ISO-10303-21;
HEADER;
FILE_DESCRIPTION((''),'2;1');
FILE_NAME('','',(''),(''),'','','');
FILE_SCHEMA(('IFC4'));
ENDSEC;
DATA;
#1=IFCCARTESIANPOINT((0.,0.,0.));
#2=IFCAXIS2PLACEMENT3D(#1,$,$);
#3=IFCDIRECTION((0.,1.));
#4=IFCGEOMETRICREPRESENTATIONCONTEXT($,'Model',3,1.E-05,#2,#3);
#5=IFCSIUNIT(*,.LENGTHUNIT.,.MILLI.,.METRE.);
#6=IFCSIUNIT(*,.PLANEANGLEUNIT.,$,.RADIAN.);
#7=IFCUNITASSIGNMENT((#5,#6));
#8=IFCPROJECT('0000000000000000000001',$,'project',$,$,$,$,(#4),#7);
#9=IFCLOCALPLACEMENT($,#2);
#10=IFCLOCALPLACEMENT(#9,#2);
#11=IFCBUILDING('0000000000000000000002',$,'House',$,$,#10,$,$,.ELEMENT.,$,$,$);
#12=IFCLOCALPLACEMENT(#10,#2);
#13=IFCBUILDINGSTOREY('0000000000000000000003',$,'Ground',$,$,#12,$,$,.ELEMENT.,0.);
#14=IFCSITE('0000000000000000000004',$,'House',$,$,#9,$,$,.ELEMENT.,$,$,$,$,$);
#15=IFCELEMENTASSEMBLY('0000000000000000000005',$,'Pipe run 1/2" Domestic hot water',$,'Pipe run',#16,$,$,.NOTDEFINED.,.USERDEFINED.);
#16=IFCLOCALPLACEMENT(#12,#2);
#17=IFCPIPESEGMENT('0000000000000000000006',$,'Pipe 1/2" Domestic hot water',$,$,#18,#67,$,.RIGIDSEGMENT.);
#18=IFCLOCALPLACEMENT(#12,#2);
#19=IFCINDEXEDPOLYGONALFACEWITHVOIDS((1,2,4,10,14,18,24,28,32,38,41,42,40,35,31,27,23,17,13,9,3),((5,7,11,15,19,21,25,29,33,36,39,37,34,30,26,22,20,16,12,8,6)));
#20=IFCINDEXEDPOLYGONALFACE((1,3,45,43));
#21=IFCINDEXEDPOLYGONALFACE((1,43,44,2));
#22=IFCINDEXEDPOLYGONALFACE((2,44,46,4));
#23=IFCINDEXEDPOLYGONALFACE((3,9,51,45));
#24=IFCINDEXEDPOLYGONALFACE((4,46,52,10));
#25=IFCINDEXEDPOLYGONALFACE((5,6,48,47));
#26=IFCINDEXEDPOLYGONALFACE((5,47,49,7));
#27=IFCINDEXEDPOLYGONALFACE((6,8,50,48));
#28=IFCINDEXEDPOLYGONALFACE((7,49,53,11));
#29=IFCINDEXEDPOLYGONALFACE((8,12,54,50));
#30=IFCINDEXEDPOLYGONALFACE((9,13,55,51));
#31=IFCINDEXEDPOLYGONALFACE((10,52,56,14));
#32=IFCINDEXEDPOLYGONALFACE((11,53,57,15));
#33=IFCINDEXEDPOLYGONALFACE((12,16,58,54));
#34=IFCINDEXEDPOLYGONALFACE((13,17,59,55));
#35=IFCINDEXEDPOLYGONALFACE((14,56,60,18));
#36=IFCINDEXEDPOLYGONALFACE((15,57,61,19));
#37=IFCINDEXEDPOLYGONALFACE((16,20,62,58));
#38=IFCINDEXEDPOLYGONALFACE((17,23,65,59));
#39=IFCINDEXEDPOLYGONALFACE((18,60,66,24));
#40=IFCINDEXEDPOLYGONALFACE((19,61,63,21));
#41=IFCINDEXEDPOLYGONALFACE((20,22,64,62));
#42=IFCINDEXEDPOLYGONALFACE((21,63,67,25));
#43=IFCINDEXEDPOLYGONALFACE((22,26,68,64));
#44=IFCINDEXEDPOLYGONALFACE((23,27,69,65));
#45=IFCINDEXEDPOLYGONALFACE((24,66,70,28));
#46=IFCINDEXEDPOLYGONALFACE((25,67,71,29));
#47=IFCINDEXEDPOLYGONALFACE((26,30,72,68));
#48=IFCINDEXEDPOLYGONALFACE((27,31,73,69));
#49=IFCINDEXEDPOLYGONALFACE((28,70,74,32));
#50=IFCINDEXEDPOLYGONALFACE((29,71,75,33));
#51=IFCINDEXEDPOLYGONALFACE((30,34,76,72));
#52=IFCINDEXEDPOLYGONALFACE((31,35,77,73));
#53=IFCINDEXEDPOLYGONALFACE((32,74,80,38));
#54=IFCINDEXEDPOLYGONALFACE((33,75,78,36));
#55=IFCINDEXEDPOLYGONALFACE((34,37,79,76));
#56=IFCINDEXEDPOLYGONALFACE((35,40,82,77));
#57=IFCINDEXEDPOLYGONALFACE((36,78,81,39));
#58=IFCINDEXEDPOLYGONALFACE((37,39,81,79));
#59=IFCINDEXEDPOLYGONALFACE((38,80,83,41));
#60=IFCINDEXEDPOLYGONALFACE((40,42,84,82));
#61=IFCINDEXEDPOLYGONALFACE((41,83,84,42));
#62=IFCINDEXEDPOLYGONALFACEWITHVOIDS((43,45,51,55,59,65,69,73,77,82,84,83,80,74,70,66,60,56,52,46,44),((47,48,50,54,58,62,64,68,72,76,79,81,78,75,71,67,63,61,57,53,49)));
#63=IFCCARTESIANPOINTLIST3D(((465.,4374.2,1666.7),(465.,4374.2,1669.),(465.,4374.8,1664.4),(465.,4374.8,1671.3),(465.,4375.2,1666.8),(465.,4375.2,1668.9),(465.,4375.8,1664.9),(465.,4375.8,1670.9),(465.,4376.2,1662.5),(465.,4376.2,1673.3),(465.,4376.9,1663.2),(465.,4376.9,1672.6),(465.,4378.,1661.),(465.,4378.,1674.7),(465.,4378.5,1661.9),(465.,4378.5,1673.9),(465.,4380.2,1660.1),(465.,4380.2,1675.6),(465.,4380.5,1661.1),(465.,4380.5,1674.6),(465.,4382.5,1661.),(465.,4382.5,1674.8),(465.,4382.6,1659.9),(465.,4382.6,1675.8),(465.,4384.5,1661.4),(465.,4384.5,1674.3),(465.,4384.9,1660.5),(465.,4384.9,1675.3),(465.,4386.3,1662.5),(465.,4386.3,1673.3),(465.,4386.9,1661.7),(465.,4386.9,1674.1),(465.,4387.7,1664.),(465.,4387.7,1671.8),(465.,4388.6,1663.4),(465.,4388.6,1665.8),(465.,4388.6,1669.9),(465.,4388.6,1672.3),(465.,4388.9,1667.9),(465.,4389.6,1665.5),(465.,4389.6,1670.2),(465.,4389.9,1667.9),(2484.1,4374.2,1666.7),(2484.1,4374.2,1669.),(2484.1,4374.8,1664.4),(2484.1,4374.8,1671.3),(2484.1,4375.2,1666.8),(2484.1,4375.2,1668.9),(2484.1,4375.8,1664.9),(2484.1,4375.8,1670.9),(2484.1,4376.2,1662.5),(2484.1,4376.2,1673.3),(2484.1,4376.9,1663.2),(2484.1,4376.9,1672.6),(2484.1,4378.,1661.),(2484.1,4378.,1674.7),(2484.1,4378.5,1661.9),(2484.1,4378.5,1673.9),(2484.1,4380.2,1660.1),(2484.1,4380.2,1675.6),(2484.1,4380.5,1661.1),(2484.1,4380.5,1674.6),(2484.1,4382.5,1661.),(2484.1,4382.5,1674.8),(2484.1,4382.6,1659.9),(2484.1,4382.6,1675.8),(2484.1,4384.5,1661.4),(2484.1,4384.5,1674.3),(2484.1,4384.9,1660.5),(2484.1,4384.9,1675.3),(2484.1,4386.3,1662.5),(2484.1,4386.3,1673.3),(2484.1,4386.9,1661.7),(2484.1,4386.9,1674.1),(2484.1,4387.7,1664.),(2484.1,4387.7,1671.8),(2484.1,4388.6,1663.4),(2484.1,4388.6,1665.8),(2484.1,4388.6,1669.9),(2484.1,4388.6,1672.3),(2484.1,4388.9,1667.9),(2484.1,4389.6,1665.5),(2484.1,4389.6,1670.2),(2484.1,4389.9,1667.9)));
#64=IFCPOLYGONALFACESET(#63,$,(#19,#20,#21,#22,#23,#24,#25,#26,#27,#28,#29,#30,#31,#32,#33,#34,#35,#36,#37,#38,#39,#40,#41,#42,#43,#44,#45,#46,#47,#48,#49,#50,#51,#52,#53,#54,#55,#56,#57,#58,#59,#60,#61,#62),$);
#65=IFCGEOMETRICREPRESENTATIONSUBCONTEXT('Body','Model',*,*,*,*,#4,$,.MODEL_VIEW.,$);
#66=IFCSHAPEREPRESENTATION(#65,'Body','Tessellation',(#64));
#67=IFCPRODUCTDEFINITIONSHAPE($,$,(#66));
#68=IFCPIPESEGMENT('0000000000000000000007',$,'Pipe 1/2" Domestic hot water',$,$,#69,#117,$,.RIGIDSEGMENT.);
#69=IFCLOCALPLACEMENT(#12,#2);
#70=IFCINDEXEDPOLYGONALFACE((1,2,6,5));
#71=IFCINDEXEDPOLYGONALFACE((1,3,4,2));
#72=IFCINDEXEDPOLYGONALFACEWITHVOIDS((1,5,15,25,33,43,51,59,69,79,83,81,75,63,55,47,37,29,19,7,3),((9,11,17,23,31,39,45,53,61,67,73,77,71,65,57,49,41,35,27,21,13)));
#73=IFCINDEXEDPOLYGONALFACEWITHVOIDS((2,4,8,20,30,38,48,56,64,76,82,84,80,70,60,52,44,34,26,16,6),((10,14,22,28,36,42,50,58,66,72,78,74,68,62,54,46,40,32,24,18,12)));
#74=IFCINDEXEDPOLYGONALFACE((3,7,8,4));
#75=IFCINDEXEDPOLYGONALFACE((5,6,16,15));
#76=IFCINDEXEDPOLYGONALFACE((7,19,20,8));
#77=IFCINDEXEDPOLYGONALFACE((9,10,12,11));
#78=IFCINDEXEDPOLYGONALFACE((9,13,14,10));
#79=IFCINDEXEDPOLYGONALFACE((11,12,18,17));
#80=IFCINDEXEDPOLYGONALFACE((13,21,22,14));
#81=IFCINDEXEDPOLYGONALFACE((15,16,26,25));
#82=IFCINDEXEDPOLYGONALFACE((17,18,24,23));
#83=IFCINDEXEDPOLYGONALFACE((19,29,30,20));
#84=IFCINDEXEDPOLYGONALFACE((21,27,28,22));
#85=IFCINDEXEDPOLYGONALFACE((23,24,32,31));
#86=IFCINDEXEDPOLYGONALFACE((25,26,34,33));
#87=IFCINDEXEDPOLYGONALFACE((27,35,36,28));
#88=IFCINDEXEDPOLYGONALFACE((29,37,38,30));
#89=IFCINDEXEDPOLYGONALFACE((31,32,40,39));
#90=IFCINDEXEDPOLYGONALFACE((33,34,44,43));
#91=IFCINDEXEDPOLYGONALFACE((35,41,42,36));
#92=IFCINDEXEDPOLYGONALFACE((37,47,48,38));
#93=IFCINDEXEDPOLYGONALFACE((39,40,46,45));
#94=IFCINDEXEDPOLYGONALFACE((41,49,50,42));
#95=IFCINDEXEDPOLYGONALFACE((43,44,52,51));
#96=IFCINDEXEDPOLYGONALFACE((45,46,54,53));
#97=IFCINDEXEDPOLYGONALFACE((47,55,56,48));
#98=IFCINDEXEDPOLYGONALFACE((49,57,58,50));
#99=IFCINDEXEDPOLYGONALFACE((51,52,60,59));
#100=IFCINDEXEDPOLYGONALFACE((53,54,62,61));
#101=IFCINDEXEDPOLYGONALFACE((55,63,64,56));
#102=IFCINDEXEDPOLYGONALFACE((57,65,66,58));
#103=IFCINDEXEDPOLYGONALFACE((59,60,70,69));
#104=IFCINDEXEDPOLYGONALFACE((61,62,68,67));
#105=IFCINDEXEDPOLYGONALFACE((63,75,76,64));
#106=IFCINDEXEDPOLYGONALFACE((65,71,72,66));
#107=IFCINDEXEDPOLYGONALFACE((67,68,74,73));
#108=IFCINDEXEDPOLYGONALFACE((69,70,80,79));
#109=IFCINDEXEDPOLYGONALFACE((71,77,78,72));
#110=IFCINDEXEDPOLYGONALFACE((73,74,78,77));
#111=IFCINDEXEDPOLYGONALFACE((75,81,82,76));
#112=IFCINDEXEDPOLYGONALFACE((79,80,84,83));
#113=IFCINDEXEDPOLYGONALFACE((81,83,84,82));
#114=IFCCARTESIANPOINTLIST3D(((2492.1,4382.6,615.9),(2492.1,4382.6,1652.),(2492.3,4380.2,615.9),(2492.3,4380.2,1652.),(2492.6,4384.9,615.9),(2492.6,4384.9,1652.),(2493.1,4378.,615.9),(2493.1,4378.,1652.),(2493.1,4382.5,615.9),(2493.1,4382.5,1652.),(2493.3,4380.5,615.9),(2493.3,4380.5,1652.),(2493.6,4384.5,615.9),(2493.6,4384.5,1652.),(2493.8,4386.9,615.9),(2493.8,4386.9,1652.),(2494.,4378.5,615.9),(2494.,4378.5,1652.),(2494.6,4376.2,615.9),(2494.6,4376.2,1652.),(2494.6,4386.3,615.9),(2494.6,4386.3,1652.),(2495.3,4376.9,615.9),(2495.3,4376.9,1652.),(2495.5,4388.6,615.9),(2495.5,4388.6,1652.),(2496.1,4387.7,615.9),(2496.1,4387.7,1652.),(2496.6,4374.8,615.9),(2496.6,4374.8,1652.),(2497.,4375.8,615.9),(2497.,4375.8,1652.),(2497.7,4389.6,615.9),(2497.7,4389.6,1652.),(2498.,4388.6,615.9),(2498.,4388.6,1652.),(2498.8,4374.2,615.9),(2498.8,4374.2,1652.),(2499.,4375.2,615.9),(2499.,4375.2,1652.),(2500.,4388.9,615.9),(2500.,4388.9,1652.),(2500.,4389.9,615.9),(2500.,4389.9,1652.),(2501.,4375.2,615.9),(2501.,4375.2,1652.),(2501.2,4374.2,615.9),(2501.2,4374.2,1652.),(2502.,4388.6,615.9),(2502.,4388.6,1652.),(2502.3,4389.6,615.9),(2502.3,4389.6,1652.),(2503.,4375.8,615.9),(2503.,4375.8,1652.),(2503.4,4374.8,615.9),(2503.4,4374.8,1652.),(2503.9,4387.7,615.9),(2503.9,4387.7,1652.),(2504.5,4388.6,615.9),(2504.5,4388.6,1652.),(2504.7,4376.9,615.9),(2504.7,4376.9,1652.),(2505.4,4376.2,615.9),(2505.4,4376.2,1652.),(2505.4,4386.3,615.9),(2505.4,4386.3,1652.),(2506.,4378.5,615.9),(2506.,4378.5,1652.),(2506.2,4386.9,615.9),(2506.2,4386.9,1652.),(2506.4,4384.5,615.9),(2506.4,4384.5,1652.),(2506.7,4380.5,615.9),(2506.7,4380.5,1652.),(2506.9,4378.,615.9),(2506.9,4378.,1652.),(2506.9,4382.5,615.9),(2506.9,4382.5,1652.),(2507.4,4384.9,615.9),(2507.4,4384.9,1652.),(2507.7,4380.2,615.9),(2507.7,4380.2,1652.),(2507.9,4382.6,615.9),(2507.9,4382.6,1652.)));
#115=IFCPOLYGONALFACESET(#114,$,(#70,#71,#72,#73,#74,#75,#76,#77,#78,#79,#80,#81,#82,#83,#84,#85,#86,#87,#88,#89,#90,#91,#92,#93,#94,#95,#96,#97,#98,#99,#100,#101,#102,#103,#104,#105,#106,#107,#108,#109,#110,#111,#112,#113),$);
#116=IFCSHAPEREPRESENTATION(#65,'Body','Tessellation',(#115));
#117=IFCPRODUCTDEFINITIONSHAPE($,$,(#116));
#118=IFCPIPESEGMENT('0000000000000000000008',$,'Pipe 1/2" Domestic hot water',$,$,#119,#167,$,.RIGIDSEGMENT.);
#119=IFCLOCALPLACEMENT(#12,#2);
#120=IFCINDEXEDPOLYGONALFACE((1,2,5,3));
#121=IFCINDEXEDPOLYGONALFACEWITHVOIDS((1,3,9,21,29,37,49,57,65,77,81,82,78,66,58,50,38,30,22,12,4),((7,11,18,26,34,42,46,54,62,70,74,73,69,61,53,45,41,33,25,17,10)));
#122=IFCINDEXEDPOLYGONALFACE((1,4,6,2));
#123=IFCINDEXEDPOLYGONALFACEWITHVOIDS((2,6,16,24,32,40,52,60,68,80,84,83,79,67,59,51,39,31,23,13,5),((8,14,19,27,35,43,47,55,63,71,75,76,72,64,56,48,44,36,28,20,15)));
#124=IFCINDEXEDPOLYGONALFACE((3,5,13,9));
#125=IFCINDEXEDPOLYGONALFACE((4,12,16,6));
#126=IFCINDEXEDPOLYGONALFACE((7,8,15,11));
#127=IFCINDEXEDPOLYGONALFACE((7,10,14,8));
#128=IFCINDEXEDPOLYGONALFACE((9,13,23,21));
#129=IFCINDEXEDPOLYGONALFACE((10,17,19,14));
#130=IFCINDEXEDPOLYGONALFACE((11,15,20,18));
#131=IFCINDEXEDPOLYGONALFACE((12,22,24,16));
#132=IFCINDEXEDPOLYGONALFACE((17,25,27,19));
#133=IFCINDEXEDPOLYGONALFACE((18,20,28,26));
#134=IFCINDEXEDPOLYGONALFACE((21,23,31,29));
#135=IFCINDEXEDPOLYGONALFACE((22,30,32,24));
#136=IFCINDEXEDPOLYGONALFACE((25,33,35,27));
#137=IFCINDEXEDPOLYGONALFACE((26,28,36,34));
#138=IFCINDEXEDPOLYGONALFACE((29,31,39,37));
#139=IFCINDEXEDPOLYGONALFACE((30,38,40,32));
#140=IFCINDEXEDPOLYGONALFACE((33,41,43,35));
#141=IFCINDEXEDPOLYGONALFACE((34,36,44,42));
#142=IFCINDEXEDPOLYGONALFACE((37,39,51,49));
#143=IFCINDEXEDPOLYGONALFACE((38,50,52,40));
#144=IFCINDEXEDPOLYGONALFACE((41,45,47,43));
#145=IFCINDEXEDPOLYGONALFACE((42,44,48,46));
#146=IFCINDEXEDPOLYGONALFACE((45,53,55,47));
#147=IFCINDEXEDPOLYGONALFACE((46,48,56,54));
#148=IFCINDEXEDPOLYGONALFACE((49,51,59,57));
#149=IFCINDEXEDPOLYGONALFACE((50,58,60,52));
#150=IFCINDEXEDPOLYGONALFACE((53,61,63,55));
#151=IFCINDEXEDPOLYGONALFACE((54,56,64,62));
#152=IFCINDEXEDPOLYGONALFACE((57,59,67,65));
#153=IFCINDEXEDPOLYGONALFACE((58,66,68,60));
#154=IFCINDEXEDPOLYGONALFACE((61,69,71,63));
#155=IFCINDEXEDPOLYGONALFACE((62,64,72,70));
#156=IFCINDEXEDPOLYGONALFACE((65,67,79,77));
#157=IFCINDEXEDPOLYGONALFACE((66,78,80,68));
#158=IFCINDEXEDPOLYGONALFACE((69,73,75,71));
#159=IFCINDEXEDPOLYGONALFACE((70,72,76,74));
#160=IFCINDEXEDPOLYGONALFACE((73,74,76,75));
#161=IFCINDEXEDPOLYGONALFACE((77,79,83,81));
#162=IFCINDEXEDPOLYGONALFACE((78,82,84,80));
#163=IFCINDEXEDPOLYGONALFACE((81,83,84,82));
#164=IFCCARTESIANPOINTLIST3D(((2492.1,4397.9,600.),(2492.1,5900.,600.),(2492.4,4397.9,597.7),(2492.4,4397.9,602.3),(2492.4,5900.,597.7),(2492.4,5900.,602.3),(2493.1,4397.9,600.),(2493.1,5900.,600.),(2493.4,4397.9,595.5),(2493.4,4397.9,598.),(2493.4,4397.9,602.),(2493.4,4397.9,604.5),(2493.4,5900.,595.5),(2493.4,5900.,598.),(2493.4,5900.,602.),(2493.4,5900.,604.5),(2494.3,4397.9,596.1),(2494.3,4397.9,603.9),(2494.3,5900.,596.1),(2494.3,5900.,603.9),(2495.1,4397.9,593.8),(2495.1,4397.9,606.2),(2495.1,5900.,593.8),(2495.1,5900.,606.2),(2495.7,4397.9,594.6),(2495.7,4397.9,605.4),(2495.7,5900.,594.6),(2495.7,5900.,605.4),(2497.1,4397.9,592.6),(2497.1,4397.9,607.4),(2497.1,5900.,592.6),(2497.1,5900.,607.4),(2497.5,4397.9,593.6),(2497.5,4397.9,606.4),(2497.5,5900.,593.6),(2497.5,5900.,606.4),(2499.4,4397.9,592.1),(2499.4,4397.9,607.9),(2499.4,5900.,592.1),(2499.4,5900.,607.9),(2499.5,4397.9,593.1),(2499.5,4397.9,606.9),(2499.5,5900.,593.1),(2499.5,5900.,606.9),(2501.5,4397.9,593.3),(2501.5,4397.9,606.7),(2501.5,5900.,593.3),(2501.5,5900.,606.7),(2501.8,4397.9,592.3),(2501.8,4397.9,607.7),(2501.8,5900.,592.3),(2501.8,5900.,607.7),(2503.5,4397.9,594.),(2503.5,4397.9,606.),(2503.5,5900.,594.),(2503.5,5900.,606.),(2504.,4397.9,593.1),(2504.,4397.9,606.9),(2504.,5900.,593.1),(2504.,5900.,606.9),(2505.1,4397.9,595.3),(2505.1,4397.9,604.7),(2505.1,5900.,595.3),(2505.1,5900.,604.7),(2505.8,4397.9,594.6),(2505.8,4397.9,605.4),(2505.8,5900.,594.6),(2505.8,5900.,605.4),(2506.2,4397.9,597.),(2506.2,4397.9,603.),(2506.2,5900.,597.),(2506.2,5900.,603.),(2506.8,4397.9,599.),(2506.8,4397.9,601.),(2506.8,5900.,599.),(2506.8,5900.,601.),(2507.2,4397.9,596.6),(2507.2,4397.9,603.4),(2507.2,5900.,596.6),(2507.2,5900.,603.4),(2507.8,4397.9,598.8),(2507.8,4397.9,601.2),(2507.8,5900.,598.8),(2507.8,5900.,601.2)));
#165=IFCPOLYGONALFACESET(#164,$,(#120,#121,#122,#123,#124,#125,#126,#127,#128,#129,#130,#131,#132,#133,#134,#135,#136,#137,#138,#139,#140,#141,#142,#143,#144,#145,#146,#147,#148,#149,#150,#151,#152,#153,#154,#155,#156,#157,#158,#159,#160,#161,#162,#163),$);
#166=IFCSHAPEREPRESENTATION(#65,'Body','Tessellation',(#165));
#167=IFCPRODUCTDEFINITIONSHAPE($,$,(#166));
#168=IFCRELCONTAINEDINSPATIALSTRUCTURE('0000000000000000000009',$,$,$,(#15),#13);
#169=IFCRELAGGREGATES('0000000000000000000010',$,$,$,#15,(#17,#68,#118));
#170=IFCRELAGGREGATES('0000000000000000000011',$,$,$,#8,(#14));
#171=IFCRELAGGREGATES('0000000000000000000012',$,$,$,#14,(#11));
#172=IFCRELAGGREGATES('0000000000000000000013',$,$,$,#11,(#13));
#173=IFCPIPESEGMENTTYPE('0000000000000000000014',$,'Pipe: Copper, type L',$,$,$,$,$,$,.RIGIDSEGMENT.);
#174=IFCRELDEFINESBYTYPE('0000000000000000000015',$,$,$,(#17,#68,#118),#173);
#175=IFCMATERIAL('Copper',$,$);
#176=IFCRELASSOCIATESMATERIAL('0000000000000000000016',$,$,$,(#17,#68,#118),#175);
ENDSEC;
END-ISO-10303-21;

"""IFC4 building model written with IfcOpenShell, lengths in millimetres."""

from ifc_helpers import new_model, si_unit, direction, frame, origin, origin_with_axes, origin_2d, place, context, subcontext, project, spatial, hollow_circle, extrude, material, type_object, element, aggregate, save


model = new_model("IFC4")

# Units and contexts
model_context = context("Model", 3, precision=1e-05, world=origin(), true_north=direction((0.0, 1.0)))
body_context = subcontext(model_context, "Body", "Model", "MODEL_VIEW")
ifc_project = project(units=[si_unit("LENGTHUNIT", "METRE", prefix="MILLI"), si_unit("PLANEANGLEUNIT", "RADIAN")], contexts=[model_context])

# Site, building, storey
site_placement = place(None, origin())
site = spatial("IfcSite", under=ifc_project, at=site_placement, Name="House", CompositionType="ELEMENT")
building_placement = place(site_placement, origin())
building = spatial("IfcBuilding", under=site, at=building_placement, Name="House", CompositionType="ELEMENT")
storey_placement = place(building_placement, origin())
storey = spatial("IfcBuildingStorey", under=building, at=storey_placement, Name="Ground", CompositionType="ELEMENT", Elevation=0.0)

# Element assembly, pipe segments
ifc_material = material(Name="Copper")
pipe_segment_type = type_object("IfcPipeSegmentType", Name="Pipe: Copper, type L", PredefinedType="RIGIDSEGMENT")
assembly_1_placement = place(storey_placement, origin_with_axes())
assembly_1 = element("IfcElementAssembly", 1, at=assembly_1_placement, inside=storey, Name="Pipe run 1/2\" Domestic hot water", ObjectType="Pipe run", AssemblyPlace="NOTDEFINED", PredefinedType="USERDEFINED")
pipe_segment_1_placement = place(storey_placement, origin_with_axes())
pipe_segment_1 = element("IfcPipeSegment", 2, at=pipe_segment_1_placement, type_object=pipe_segment_type, material=ifc_material, Name="Pipe 1/2\" Domestic hot water", PredefinedType="RIGIDSEGMENT", context=body_context, shape_type="SweptSolid", body=[
    extrude(hollow_circle(Radius=7.9, WallThickness=1.0, at=origin_2d()), frame((465.0, 4382.0, 1667.9), z_axis=(1.0, 0.0, 0.0), x_axis=(0.0, 1.0, 0.0)), (0.0, 0.0, 1.0), 2019.1),
])
pipe_segment_2_placement = place(storey_placement, origin_with_axes())
pipe_segment_2 = element("IfcPipeSegment", 3, at=pipe_segment_2_placement, type_object=pipe_segment_type, material=ifc_material, Name="Pipe 1/2\" Domestic hot water", PredefinedType="RIGIDSEGMENT", context=body_context, shape_type="SweptSolid", body=[
    extrude(hollow_circle(Radius=7.9, WallThickness=1.0, at=origin_2d()), frame((2500.0, 4382.0, 1652.0), z_axis=(0.0, 0.0, -1.0), x_axis=(0.0, 1.0, 0.0)), (0.0, 0.0, 1.0), 1036.1),
])
pipe_segment_3_placement = place(storey_placement, origin_with_axes())
pipe_segment_3 = element("IfcPipeSegment", 4, at=pipe_segment_3_placement, type_object=pipe_segment_type, material=ifc_material, Name="Pipe 1/2\" Domestic hot water", PredefinedType="RIGIDSEGMENT", context=body_context, shape_type="SweptSolid", body=[
    extrude(hollow_circle(Radius=7.9, WallThickness=1.0, at=origin_2d()), frame((2500.0, 4397.9, 600.0), z_axis=(0.0, 1.0, 0.0), x_axis=(-1.0, 0.0, 0.0)), (0.0, 0.0, 1.0), 1502.1),
])

aggregate(assembly_1, [pipe_segment_1, pipe_segment_2, pipe_segment_3])

save(model, "model.ifc")
